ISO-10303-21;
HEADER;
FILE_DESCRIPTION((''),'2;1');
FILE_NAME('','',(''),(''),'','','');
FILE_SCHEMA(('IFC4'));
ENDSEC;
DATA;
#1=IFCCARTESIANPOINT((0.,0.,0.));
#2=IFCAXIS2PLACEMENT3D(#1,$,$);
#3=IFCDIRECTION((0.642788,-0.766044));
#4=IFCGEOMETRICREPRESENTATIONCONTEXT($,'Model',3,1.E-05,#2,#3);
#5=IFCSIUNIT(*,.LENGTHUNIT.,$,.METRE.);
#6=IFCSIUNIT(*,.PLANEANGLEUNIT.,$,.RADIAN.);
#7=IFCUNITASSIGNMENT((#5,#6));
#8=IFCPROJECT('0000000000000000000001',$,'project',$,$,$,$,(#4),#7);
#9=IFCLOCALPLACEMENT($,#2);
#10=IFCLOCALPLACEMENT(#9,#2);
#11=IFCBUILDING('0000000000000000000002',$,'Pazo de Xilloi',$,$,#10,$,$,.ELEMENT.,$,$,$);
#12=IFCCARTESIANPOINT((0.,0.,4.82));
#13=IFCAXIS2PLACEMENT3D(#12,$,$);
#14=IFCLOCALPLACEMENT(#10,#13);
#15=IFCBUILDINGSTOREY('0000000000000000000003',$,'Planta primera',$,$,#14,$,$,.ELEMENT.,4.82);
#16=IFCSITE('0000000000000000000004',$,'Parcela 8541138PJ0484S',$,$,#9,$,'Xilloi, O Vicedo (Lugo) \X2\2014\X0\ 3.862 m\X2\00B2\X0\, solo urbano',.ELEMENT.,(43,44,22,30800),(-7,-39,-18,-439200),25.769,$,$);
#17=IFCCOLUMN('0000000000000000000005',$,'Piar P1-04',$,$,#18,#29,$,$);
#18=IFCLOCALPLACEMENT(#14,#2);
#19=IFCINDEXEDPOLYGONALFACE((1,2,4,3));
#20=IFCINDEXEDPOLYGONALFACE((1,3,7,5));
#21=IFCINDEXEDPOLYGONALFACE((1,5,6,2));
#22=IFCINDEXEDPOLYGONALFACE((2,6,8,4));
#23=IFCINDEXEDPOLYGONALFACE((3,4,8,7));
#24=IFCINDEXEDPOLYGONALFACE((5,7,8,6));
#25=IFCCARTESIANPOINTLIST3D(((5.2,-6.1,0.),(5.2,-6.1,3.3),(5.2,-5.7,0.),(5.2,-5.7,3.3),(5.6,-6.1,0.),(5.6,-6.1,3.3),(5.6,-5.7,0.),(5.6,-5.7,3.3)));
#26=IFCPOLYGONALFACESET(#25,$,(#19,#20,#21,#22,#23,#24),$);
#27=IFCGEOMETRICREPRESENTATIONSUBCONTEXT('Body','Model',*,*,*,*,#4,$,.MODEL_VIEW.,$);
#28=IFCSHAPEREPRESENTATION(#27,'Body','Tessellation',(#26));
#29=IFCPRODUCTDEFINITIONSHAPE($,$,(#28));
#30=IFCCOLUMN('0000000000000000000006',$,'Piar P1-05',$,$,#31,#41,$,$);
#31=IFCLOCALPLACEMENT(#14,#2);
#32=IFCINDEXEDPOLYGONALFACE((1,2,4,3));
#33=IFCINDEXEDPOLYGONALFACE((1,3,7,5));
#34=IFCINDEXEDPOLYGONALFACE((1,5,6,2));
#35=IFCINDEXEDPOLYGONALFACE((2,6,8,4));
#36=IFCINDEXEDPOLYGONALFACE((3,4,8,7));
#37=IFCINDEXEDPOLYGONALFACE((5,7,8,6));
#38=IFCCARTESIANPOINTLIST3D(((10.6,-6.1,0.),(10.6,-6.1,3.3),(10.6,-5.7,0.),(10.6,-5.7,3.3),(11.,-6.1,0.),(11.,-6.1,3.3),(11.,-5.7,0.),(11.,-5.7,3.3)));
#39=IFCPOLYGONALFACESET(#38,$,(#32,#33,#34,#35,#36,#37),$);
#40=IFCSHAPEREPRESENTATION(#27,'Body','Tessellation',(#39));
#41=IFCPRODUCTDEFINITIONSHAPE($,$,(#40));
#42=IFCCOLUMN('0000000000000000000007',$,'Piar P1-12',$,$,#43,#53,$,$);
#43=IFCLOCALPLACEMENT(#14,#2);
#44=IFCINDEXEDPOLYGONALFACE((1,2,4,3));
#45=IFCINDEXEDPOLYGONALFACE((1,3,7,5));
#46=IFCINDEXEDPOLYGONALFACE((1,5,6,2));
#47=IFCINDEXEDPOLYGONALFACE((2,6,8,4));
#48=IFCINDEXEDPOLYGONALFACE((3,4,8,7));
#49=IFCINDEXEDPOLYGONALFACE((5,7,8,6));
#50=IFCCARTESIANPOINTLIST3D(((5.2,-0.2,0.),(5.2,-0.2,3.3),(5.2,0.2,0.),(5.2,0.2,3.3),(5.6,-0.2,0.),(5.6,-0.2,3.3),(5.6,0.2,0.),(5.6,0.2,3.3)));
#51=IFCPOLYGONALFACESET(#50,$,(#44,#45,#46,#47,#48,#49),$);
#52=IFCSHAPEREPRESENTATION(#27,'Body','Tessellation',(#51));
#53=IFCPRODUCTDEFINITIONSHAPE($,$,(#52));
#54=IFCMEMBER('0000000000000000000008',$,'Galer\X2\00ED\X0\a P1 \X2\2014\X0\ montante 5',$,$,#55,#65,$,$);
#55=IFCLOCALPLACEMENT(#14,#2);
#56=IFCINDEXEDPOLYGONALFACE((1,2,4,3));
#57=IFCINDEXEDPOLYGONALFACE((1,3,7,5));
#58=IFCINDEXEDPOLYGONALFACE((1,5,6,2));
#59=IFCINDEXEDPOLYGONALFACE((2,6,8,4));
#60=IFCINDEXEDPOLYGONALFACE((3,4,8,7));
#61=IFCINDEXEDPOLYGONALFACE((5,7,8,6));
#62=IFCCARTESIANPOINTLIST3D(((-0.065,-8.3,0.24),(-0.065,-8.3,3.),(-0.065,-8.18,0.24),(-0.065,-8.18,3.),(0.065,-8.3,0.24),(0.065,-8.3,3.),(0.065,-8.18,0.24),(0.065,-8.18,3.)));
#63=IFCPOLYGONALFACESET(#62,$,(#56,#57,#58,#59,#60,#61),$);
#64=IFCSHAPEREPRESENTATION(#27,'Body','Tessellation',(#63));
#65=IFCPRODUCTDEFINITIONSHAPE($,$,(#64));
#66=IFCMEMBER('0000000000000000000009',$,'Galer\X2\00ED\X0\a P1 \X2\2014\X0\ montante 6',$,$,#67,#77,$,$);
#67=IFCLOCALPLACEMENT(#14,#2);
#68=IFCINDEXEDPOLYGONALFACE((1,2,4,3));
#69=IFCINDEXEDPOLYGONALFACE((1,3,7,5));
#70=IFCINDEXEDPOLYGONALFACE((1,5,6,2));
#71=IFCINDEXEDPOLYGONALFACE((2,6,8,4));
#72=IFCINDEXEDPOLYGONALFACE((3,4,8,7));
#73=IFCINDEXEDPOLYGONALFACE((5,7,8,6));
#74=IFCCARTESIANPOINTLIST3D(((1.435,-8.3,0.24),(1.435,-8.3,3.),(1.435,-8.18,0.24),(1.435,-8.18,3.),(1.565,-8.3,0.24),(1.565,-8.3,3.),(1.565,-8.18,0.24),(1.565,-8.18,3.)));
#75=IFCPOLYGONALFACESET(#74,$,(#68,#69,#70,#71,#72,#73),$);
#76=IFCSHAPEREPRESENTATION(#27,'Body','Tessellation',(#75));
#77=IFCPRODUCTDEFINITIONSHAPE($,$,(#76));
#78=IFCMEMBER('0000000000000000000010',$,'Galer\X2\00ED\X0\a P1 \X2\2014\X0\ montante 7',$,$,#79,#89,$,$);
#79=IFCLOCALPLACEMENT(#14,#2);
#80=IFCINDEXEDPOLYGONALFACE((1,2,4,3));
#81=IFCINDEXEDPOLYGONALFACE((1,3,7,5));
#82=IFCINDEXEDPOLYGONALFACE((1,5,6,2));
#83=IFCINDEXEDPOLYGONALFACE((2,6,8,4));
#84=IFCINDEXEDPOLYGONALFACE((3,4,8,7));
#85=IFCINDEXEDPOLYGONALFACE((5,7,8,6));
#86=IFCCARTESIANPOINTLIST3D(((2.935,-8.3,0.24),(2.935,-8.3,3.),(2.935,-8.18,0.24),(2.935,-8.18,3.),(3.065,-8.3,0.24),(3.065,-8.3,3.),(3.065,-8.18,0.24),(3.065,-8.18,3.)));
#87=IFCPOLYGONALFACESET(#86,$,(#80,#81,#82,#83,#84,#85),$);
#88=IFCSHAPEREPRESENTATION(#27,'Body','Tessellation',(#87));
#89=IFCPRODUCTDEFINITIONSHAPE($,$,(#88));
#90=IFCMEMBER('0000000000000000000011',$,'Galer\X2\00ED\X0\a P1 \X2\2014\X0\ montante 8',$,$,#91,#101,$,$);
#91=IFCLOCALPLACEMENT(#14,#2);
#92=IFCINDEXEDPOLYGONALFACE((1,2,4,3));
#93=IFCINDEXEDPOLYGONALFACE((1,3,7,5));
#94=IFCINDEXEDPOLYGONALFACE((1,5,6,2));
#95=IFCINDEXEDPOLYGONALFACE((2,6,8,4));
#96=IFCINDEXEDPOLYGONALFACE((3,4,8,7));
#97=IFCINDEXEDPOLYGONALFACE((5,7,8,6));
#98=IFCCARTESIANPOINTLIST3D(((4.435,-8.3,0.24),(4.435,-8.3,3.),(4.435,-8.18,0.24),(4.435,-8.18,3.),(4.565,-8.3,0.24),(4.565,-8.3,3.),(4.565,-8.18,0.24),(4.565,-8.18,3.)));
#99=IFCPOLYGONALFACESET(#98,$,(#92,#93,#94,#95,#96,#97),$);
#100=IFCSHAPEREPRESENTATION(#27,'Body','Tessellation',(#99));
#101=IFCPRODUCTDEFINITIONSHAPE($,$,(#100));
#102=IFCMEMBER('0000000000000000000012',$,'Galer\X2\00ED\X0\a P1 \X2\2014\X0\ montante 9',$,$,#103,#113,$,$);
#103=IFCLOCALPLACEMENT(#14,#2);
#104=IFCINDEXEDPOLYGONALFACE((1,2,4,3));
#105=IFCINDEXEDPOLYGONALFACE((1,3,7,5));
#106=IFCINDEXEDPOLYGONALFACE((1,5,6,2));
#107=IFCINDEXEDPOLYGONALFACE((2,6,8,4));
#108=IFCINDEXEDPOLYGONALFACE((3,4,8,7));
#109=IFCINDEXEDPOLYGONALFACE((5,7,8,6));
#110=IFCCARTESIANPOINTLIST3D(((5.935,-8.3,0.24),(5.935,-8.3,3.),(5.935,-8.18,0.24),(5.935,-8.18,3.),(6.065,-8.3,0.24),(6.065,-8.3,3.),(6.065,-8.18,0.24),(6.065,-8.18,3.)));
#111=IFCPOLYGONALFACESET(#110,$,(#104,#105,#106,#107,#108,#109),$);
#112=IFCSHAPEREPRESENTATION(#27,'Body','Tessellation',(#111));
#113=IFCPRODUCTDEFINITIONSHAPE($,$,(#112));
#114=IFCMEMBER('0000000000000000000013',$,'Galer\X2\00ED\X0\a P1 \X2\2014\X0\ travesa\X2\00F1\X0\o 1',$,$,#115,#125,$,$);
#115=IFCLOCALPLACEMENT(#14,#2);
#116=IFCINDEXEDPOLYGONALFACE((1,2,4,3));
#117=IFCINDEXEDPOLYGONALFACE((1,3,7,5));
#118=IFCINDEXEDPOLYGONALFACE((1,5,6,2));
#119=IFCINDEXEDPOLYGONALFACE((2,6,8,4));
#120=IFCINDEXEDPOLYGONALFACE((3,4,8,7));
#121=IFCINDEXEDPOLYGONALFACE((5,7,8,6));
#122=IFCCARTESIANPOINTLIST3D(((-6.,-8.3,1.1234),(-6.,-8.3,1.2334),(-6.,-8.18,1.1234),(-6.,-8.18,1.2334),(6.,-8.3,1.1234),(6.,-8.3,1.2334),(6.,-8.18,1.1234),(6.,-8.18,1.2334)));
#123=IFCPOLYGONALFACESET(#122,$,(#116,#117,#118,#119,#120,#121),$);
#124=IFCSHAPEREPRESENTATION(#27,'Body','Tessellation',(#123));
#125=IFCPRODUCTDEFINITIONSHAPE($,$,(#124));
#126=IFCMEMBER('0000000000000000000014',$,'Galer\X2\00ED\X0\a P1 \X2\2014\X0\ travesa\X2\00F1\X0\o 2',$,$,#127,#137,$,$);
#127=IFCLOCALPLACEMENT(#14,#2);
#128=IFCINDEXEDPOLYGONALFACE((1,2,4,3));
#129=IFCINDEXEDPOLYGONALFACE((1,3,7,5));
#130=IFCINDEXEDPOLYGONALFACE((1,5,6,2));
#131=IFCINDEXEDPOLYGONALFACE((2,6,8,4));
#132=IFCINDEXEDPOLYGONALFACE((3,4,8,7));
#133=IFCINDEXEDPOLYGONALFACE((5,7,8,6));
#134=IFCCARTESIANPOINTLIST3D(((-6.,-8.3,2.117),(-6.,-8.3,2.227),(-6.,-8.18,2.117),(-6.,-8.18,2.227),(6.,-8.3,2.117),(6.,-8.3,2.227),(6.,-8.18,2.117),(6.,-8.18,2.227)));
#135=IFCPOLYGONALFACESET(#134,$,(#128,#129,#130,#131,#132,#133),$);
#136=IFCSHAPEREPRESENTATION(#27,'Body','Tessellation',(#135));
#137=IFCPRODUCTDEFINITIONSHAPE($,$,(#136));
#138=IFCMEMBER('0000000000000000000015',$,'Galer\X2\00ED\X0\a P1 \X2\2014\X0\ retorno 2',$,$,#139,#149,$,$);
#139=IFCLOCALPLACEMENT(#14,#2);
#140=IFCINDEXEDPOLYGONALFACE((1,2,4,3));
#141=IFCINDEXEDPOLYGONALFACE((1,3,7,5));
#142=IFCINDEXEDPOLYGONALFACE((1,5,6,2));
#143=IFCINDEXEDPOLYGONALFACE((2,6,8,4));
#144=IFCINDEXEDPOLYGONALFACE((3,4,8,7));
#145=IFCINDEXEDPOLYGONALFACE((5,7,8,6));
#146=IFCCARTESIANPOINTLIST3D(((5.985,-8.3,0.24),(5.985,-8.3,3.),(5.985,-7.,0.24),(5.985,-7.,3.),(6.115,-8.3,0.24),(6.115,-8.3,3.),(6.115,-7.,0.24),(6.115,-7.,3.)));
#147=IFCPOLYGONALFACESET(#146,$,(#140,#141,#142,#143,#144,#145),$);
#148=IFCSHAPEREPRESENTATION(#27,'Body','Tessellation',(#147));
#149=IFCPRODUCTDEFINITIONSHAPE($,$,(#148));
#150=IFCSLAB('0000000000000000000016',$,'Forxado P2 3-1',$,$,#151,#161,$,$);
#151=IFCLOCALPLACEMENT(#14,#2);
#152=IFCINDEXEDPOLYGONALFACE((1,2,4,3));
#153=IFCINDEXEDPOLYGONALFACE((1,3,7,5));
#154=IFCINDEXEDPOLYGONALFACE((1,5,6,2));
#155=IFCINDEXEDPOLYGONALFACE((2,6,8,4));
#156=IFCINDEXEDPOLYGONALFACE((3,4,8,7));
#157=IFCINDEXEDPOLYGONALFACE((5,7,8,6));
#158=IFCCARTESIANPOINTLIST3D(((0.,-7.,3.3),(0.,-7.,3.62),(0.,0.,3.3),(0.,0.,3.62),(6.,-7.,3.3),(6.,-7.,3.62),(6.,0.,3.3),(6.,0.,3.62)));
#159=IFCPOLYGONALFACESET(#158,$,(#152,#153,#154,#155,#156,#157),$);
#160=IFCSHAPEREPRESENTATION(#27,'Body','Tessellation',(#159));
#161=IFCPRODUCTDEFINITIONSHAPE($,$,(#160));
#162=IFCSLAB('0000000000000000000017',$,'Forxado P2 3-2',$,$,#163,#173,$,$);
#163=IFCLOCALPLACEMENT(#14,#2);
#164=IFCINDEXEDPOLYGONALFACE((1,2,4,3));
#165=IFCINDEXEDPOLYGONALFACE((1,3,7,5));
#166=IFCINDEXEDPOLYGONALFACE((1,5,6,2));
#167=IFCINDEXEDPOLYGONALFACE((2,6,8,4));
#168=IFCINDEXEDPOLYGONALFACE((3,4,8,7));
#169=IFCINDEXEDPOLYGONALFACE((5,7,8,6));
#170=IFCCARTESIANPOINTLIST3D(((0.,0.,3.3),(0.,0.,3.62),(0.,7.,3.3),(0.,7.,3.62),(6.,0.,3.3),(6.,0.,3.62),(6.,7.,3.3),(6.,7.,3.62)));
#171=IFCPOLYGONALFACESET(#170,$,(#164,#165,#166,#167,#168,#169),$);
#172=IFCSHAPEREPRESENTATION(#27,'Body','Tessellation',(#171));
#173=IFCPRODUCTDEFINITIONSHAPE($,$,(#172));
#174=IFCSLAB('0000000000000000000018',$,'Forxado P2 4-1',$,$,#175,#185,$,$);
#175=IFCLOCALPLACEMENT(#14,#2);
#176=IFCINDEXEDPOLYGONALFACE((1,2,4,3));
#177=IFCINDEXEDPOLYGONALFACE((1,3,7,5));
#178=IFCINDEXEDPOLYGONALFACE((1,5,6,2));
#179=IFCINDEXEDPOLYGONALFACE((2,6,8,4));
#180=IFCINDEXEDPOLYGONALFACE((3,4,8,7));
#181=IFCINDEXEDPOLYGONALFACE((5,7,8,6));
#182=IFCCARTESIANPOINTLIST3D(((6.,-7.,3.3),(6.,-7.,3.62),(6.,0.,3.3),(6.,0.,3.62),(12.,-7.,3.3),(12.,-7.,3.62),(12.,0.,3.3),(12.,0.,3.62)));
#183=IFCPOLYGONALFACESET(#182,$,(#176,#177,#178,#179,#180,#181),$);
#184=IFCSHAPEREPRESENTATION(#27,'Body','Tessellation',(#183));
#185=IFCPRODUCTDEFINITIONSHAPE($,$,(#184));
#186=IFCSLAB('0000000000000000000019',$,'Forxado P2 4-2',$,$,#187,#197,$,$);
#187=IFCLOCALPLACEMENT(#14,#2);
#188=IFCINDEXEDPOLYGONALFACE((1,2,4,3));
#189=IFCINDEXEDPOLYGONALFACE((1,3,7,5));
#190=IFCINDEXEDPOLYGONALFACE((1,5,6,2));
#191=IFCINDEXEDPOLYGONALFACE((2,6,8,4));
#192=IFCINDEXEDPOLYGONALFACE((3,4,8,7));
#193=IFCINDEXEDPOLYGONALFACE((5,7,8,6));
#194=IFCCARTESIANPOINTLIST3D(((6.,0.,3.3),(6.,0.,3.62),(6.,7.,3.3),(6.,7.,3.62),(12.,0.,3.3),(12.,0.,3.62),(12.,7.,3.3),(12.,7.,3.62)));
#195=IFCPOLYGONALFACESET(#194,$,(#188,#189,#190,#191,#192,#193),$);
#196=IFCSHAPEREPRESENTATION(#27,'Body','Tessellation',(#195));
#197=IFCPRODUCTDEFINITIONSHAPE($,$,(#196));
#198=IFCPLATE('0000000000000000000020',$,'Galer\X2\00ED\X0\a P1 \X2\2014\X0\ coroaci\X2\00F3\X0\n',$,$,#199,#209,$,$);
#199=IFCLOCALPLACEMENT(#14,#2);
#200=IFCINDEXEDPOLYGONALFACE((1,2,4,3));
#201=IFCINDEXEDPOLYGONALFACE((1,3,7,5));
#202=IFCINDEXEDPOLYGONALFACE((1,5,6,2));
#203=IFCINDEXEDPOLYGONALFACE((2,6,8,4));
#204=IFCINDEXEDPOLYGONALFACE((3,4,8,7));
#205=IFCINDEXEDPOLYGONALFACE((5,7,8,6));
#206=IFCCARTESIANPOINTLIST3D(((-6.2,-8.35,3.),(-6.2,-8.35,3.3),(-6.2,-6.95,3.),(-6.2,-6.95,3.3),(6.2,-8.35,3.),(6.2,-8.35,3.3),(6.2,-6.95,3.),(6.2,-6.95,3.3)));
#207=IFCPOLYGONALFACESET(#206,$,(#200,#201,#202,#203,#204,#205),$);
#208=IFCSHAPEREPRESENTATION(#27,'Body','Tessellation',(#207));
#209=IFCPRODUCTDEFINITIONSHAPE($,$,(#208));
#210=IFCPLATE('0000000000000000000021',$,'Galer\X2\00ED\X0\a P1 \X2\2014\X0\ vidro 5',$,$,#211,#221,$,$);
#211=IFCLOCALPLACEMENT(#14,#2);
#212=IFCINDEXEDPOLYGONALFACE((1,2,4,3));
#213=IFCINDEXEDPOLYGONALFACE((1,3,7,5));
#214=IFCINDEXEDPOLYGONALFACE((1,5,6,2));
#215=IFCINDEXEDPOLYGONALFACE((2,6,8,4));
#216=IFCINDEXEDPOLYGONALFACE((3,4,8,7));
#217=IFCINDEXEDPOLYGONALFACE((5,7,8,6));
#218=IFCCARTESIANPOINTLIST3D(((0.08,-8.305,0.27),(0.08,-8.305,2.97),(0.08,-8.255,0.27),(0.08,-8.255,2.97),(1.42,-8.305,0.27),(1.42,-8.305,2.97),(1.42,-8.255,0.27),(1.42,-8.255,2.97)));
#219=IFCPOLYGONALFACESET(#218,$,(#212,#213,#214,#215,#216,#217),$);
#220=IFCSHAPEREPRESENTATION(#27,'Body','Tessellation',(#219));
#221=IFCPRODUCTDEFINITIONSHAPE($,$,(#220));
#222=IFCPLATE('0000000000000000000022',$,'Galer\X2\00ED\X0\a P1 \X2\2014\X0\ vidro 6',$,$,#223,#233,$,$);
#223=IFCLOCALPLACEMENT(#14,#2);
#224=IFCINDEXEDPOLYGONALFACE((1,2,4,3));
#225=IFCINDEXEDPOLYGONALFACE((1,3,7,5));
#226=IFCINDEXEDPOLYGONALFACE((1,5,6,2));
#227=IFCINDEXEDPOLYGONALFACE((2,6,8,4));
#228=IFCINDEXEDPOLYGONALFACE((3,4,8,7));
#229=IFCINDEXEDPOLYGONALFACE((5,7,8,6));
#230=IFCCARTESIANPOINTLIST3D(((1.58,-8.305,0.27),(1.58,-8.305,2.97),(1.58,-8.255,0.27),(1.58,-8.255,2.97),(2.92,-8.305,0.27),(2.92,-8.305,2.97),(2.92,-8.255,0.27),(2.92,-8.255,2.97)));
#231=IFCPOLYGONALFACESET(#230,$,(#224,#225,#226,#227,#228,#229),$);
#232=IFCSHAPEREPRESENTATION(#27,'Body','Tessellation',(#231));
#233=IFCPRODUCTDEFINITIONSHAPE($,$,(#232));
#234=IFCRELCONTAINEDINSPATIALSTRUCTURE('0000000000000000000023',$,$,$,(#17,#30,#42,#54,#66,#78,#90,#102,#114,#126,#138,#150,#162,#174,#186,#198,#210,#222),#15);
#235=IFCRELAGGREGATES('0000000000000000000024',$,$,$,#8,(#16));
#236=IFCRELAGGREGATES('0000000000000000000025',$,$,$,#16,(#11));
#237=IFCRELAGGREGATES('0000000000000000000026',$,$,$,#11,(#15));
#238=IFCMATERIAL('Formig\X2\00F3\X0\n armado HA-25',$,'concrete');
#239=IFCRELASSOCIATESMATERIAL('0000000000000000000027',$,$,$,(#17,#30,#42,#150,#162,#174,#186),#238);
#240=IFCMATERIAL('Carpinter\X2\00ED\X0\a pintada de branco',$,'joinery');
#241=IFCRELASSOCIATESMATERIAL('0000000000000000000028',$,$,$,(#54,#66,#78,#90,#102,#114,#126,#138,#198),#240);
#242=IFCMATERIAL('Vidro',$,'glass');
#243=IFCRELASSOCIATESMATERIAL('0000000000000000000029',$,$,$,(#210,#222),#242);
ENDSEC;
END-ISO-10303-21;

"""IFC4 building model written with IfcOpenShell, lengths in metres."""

from ifc_helpers import new_model, si_unit, direction, frame, origin, origin_2d, place, context, subcontext, project, spatial, rectangle, extrude, material, element, save


model = new_model("IFC4")

# Units and contexts
model_context = context("Model", 3, precision=1e-05, world=origin(), true_north=direction((0.642788, -0.766044)))
body_context = subcontext(model_context, "Body", "Model", "MODEL_VIEW")
ifc_project = project(units=[si_unit("LENGTHUNIT", "METRE"), si_unit("PLANEANGLEUNIT", "RADIAN")], contexts=[model_context])

# Site, building, storey
site_placement = place(None, origin())
site = spatial("IfcSite", under=ifc_project, at=site_placement, Name="Parcela 8541138PJ0484S", LongName="Xilloi, O Vicedo (Lugo) — 3.862 m², solo urbano", CompositionType="ELEMENT", RefLatitude=(43, 44, 22, 30800), RefLongitude=(-7, -39, -18, -439200), RefElevation=25.769)
building_placement = place(site_placement, origin())
building = spatial("IfcBuilding", under=site, at=building_placement, Name="Pazo de Xilloi", CompositionType="ELEMENT")
storey_placement = place(building_placement, frame((0.0, 0.0, 4.82)))
storey = spatial("IfcBuildingStorey", under=building, at=storey_placement, Name="Planta primera", CompositionType="ELEMENT", Elevation=4.82)

# Columns
ifc_material_1 = material(Name="Formigón armado HA-25", Category="concrete")
for number, where, name in (
    (1, (5.4, -5.9, 1.65), "Piar P1-04"),
    (2, (10.8, -5.9, 1.65), "Piar P1-05"),
    (3, (5.4, 0.0, 1.65), "Piar P1-12"),
):
    element("IfcColumn", number, at=place(storey_placement, frame(where)), inside=storey, material=ifc_material_1, Name=name, context=body_context, shape_type="SweptSolid", body=[
        extrude(rectangle(XDim=0.4, YDim=0.4, at=origin_2d()), frame((0.0, 0.0, -1.65)), (0.0, 0.0, 1.0), 3.3),
    ])

# Members
ifc_material_2 = material(Name="Carpintería pintada de branco", Category="joinery")
for number, where, name in (
    (4, (0.0, -8.24, 1.62), "Galería P1 — montante 5"),
    (5, (1.5, -8.24, 1.62), "Galería P1 — montante 6"),
    (6, (3.0, -8.24, 1.62), "Galería P1 — montante 7"),
    (7, (4.5, -8.24, 1.62), "Galería P1 — montante 8"),
    (8, (6.0, -8.24, 1.62), "Galería P1 — montante 9"),
):
    element("IfcMember", number, at=place(storey_placement, frame(where)), inside=storey, material=ifc_material_2, Name=name, context=body_context, shape_type="SweptSolid", body=[
        extrude(rectangle(XDim=0.13, YDim=0.12, at=origin_2d()), frame((0.0, 0.0, -1.38)), (0.0, 0.0, 1.0), 2.76),
    ])
for number, where, name in (
    (9, (0.0, -8.24, 1.1784), "Galería P1 — travesaño 1"),
    (10, (0.0, -8.24, 2.172), "Galería P1 — travesaño 2"),
):
    element("IfcMember", number, at=place(storey_placement, frame(where)), inside=storey, material=ifc_material_2, Name=name, context=body_context, shape_type="SweptSolid", body=[
        extrude(rectangle(XDim=12.0, YDim=0.12, at=origin_2d()), frame((0.0, 0.0, -0.055)), (0.0, 0.0, 1.0), 0.11),
    ])
member_placement = place(storey_placement, frame((6.05, -7.65, 1.62)))
element("IfcMember", 11, at=member_placement, inside=storey, material=ifc_material_2, Name="Galería P1 — retorno 2", context=body_context, shape_type="SweptSolid", body=[
    extrude(rectangle(XDim=0.13, YDim=1.3, at=origin_2d()), frame((0.0, 0.0, -1.38)), (0.0, 0.0, 1.0), 2.76),
])

# Slabs
for number, where, name in (
    (12, (3.0, -3.5, 3.46), "Forxado P2 3-1"),
    (13, (3.0, 3.5, 3.46), "Forxado P2 3-2"),
    (14, (9.0, -3.5, 3.46), "Forxado P2 4-1"),
    (15, (9.0, 3.5, 3.46), "Forxado P2 4-2"),
):
    element("IfcSlab", number, at=place(storey_placement, frame(where)), inside=storey, material=ifc_material_1, Name=name, context=body_context, shape_type="SweptSolid", body=[
        extrude(rectangle(XDim=6.0, YDim=7.0, at=origin_2d()), frame((0.0, 0.0, -0.16)), (0.0, 0.0, 1.0), 0.32),
    ])

# Plates
plate_1_placement = place(storey_placement, frame((0.0, -7.65, 3.15)))
element("IfcPlate", 16, at=plate_1_placement, inside=storey, material=ifc_material_2, Name="Galería P1 — coroación", context=body_context, shape_type="SweptSolid", body=[
    extrude(rectangle(XDim=12.4, YDim=1.4, at=origin_2d()), frame((0.0, 0.0, -0.15)), (0.0, 0.0, 1.0), 0.3),
])
ifc_material_3 = material(Name="Vidro", Category="glass")
for number, where, name in (
    (17, (0.75, -8.28, 1.62), "Galería P1 — vidro 5"),
    (18, (2.25, -8.28, 1.62), "Galería P1 — vidro 6"),
):
    element("IfcPlate", number, at=place(storey_placement, frame(where)), inside=storey, material=ifc_material_3, Name=name, context=body_context, shape_type="SweptSolid", body=[
        extrude(rectangle(XDim=1.34, YDim=0.05, at=origin_2d()), frame((0.0, 0.0, -1.35)), (0.0, 0.0, 1.0), 2.7),
    ])

save(model, "model.ifc")
